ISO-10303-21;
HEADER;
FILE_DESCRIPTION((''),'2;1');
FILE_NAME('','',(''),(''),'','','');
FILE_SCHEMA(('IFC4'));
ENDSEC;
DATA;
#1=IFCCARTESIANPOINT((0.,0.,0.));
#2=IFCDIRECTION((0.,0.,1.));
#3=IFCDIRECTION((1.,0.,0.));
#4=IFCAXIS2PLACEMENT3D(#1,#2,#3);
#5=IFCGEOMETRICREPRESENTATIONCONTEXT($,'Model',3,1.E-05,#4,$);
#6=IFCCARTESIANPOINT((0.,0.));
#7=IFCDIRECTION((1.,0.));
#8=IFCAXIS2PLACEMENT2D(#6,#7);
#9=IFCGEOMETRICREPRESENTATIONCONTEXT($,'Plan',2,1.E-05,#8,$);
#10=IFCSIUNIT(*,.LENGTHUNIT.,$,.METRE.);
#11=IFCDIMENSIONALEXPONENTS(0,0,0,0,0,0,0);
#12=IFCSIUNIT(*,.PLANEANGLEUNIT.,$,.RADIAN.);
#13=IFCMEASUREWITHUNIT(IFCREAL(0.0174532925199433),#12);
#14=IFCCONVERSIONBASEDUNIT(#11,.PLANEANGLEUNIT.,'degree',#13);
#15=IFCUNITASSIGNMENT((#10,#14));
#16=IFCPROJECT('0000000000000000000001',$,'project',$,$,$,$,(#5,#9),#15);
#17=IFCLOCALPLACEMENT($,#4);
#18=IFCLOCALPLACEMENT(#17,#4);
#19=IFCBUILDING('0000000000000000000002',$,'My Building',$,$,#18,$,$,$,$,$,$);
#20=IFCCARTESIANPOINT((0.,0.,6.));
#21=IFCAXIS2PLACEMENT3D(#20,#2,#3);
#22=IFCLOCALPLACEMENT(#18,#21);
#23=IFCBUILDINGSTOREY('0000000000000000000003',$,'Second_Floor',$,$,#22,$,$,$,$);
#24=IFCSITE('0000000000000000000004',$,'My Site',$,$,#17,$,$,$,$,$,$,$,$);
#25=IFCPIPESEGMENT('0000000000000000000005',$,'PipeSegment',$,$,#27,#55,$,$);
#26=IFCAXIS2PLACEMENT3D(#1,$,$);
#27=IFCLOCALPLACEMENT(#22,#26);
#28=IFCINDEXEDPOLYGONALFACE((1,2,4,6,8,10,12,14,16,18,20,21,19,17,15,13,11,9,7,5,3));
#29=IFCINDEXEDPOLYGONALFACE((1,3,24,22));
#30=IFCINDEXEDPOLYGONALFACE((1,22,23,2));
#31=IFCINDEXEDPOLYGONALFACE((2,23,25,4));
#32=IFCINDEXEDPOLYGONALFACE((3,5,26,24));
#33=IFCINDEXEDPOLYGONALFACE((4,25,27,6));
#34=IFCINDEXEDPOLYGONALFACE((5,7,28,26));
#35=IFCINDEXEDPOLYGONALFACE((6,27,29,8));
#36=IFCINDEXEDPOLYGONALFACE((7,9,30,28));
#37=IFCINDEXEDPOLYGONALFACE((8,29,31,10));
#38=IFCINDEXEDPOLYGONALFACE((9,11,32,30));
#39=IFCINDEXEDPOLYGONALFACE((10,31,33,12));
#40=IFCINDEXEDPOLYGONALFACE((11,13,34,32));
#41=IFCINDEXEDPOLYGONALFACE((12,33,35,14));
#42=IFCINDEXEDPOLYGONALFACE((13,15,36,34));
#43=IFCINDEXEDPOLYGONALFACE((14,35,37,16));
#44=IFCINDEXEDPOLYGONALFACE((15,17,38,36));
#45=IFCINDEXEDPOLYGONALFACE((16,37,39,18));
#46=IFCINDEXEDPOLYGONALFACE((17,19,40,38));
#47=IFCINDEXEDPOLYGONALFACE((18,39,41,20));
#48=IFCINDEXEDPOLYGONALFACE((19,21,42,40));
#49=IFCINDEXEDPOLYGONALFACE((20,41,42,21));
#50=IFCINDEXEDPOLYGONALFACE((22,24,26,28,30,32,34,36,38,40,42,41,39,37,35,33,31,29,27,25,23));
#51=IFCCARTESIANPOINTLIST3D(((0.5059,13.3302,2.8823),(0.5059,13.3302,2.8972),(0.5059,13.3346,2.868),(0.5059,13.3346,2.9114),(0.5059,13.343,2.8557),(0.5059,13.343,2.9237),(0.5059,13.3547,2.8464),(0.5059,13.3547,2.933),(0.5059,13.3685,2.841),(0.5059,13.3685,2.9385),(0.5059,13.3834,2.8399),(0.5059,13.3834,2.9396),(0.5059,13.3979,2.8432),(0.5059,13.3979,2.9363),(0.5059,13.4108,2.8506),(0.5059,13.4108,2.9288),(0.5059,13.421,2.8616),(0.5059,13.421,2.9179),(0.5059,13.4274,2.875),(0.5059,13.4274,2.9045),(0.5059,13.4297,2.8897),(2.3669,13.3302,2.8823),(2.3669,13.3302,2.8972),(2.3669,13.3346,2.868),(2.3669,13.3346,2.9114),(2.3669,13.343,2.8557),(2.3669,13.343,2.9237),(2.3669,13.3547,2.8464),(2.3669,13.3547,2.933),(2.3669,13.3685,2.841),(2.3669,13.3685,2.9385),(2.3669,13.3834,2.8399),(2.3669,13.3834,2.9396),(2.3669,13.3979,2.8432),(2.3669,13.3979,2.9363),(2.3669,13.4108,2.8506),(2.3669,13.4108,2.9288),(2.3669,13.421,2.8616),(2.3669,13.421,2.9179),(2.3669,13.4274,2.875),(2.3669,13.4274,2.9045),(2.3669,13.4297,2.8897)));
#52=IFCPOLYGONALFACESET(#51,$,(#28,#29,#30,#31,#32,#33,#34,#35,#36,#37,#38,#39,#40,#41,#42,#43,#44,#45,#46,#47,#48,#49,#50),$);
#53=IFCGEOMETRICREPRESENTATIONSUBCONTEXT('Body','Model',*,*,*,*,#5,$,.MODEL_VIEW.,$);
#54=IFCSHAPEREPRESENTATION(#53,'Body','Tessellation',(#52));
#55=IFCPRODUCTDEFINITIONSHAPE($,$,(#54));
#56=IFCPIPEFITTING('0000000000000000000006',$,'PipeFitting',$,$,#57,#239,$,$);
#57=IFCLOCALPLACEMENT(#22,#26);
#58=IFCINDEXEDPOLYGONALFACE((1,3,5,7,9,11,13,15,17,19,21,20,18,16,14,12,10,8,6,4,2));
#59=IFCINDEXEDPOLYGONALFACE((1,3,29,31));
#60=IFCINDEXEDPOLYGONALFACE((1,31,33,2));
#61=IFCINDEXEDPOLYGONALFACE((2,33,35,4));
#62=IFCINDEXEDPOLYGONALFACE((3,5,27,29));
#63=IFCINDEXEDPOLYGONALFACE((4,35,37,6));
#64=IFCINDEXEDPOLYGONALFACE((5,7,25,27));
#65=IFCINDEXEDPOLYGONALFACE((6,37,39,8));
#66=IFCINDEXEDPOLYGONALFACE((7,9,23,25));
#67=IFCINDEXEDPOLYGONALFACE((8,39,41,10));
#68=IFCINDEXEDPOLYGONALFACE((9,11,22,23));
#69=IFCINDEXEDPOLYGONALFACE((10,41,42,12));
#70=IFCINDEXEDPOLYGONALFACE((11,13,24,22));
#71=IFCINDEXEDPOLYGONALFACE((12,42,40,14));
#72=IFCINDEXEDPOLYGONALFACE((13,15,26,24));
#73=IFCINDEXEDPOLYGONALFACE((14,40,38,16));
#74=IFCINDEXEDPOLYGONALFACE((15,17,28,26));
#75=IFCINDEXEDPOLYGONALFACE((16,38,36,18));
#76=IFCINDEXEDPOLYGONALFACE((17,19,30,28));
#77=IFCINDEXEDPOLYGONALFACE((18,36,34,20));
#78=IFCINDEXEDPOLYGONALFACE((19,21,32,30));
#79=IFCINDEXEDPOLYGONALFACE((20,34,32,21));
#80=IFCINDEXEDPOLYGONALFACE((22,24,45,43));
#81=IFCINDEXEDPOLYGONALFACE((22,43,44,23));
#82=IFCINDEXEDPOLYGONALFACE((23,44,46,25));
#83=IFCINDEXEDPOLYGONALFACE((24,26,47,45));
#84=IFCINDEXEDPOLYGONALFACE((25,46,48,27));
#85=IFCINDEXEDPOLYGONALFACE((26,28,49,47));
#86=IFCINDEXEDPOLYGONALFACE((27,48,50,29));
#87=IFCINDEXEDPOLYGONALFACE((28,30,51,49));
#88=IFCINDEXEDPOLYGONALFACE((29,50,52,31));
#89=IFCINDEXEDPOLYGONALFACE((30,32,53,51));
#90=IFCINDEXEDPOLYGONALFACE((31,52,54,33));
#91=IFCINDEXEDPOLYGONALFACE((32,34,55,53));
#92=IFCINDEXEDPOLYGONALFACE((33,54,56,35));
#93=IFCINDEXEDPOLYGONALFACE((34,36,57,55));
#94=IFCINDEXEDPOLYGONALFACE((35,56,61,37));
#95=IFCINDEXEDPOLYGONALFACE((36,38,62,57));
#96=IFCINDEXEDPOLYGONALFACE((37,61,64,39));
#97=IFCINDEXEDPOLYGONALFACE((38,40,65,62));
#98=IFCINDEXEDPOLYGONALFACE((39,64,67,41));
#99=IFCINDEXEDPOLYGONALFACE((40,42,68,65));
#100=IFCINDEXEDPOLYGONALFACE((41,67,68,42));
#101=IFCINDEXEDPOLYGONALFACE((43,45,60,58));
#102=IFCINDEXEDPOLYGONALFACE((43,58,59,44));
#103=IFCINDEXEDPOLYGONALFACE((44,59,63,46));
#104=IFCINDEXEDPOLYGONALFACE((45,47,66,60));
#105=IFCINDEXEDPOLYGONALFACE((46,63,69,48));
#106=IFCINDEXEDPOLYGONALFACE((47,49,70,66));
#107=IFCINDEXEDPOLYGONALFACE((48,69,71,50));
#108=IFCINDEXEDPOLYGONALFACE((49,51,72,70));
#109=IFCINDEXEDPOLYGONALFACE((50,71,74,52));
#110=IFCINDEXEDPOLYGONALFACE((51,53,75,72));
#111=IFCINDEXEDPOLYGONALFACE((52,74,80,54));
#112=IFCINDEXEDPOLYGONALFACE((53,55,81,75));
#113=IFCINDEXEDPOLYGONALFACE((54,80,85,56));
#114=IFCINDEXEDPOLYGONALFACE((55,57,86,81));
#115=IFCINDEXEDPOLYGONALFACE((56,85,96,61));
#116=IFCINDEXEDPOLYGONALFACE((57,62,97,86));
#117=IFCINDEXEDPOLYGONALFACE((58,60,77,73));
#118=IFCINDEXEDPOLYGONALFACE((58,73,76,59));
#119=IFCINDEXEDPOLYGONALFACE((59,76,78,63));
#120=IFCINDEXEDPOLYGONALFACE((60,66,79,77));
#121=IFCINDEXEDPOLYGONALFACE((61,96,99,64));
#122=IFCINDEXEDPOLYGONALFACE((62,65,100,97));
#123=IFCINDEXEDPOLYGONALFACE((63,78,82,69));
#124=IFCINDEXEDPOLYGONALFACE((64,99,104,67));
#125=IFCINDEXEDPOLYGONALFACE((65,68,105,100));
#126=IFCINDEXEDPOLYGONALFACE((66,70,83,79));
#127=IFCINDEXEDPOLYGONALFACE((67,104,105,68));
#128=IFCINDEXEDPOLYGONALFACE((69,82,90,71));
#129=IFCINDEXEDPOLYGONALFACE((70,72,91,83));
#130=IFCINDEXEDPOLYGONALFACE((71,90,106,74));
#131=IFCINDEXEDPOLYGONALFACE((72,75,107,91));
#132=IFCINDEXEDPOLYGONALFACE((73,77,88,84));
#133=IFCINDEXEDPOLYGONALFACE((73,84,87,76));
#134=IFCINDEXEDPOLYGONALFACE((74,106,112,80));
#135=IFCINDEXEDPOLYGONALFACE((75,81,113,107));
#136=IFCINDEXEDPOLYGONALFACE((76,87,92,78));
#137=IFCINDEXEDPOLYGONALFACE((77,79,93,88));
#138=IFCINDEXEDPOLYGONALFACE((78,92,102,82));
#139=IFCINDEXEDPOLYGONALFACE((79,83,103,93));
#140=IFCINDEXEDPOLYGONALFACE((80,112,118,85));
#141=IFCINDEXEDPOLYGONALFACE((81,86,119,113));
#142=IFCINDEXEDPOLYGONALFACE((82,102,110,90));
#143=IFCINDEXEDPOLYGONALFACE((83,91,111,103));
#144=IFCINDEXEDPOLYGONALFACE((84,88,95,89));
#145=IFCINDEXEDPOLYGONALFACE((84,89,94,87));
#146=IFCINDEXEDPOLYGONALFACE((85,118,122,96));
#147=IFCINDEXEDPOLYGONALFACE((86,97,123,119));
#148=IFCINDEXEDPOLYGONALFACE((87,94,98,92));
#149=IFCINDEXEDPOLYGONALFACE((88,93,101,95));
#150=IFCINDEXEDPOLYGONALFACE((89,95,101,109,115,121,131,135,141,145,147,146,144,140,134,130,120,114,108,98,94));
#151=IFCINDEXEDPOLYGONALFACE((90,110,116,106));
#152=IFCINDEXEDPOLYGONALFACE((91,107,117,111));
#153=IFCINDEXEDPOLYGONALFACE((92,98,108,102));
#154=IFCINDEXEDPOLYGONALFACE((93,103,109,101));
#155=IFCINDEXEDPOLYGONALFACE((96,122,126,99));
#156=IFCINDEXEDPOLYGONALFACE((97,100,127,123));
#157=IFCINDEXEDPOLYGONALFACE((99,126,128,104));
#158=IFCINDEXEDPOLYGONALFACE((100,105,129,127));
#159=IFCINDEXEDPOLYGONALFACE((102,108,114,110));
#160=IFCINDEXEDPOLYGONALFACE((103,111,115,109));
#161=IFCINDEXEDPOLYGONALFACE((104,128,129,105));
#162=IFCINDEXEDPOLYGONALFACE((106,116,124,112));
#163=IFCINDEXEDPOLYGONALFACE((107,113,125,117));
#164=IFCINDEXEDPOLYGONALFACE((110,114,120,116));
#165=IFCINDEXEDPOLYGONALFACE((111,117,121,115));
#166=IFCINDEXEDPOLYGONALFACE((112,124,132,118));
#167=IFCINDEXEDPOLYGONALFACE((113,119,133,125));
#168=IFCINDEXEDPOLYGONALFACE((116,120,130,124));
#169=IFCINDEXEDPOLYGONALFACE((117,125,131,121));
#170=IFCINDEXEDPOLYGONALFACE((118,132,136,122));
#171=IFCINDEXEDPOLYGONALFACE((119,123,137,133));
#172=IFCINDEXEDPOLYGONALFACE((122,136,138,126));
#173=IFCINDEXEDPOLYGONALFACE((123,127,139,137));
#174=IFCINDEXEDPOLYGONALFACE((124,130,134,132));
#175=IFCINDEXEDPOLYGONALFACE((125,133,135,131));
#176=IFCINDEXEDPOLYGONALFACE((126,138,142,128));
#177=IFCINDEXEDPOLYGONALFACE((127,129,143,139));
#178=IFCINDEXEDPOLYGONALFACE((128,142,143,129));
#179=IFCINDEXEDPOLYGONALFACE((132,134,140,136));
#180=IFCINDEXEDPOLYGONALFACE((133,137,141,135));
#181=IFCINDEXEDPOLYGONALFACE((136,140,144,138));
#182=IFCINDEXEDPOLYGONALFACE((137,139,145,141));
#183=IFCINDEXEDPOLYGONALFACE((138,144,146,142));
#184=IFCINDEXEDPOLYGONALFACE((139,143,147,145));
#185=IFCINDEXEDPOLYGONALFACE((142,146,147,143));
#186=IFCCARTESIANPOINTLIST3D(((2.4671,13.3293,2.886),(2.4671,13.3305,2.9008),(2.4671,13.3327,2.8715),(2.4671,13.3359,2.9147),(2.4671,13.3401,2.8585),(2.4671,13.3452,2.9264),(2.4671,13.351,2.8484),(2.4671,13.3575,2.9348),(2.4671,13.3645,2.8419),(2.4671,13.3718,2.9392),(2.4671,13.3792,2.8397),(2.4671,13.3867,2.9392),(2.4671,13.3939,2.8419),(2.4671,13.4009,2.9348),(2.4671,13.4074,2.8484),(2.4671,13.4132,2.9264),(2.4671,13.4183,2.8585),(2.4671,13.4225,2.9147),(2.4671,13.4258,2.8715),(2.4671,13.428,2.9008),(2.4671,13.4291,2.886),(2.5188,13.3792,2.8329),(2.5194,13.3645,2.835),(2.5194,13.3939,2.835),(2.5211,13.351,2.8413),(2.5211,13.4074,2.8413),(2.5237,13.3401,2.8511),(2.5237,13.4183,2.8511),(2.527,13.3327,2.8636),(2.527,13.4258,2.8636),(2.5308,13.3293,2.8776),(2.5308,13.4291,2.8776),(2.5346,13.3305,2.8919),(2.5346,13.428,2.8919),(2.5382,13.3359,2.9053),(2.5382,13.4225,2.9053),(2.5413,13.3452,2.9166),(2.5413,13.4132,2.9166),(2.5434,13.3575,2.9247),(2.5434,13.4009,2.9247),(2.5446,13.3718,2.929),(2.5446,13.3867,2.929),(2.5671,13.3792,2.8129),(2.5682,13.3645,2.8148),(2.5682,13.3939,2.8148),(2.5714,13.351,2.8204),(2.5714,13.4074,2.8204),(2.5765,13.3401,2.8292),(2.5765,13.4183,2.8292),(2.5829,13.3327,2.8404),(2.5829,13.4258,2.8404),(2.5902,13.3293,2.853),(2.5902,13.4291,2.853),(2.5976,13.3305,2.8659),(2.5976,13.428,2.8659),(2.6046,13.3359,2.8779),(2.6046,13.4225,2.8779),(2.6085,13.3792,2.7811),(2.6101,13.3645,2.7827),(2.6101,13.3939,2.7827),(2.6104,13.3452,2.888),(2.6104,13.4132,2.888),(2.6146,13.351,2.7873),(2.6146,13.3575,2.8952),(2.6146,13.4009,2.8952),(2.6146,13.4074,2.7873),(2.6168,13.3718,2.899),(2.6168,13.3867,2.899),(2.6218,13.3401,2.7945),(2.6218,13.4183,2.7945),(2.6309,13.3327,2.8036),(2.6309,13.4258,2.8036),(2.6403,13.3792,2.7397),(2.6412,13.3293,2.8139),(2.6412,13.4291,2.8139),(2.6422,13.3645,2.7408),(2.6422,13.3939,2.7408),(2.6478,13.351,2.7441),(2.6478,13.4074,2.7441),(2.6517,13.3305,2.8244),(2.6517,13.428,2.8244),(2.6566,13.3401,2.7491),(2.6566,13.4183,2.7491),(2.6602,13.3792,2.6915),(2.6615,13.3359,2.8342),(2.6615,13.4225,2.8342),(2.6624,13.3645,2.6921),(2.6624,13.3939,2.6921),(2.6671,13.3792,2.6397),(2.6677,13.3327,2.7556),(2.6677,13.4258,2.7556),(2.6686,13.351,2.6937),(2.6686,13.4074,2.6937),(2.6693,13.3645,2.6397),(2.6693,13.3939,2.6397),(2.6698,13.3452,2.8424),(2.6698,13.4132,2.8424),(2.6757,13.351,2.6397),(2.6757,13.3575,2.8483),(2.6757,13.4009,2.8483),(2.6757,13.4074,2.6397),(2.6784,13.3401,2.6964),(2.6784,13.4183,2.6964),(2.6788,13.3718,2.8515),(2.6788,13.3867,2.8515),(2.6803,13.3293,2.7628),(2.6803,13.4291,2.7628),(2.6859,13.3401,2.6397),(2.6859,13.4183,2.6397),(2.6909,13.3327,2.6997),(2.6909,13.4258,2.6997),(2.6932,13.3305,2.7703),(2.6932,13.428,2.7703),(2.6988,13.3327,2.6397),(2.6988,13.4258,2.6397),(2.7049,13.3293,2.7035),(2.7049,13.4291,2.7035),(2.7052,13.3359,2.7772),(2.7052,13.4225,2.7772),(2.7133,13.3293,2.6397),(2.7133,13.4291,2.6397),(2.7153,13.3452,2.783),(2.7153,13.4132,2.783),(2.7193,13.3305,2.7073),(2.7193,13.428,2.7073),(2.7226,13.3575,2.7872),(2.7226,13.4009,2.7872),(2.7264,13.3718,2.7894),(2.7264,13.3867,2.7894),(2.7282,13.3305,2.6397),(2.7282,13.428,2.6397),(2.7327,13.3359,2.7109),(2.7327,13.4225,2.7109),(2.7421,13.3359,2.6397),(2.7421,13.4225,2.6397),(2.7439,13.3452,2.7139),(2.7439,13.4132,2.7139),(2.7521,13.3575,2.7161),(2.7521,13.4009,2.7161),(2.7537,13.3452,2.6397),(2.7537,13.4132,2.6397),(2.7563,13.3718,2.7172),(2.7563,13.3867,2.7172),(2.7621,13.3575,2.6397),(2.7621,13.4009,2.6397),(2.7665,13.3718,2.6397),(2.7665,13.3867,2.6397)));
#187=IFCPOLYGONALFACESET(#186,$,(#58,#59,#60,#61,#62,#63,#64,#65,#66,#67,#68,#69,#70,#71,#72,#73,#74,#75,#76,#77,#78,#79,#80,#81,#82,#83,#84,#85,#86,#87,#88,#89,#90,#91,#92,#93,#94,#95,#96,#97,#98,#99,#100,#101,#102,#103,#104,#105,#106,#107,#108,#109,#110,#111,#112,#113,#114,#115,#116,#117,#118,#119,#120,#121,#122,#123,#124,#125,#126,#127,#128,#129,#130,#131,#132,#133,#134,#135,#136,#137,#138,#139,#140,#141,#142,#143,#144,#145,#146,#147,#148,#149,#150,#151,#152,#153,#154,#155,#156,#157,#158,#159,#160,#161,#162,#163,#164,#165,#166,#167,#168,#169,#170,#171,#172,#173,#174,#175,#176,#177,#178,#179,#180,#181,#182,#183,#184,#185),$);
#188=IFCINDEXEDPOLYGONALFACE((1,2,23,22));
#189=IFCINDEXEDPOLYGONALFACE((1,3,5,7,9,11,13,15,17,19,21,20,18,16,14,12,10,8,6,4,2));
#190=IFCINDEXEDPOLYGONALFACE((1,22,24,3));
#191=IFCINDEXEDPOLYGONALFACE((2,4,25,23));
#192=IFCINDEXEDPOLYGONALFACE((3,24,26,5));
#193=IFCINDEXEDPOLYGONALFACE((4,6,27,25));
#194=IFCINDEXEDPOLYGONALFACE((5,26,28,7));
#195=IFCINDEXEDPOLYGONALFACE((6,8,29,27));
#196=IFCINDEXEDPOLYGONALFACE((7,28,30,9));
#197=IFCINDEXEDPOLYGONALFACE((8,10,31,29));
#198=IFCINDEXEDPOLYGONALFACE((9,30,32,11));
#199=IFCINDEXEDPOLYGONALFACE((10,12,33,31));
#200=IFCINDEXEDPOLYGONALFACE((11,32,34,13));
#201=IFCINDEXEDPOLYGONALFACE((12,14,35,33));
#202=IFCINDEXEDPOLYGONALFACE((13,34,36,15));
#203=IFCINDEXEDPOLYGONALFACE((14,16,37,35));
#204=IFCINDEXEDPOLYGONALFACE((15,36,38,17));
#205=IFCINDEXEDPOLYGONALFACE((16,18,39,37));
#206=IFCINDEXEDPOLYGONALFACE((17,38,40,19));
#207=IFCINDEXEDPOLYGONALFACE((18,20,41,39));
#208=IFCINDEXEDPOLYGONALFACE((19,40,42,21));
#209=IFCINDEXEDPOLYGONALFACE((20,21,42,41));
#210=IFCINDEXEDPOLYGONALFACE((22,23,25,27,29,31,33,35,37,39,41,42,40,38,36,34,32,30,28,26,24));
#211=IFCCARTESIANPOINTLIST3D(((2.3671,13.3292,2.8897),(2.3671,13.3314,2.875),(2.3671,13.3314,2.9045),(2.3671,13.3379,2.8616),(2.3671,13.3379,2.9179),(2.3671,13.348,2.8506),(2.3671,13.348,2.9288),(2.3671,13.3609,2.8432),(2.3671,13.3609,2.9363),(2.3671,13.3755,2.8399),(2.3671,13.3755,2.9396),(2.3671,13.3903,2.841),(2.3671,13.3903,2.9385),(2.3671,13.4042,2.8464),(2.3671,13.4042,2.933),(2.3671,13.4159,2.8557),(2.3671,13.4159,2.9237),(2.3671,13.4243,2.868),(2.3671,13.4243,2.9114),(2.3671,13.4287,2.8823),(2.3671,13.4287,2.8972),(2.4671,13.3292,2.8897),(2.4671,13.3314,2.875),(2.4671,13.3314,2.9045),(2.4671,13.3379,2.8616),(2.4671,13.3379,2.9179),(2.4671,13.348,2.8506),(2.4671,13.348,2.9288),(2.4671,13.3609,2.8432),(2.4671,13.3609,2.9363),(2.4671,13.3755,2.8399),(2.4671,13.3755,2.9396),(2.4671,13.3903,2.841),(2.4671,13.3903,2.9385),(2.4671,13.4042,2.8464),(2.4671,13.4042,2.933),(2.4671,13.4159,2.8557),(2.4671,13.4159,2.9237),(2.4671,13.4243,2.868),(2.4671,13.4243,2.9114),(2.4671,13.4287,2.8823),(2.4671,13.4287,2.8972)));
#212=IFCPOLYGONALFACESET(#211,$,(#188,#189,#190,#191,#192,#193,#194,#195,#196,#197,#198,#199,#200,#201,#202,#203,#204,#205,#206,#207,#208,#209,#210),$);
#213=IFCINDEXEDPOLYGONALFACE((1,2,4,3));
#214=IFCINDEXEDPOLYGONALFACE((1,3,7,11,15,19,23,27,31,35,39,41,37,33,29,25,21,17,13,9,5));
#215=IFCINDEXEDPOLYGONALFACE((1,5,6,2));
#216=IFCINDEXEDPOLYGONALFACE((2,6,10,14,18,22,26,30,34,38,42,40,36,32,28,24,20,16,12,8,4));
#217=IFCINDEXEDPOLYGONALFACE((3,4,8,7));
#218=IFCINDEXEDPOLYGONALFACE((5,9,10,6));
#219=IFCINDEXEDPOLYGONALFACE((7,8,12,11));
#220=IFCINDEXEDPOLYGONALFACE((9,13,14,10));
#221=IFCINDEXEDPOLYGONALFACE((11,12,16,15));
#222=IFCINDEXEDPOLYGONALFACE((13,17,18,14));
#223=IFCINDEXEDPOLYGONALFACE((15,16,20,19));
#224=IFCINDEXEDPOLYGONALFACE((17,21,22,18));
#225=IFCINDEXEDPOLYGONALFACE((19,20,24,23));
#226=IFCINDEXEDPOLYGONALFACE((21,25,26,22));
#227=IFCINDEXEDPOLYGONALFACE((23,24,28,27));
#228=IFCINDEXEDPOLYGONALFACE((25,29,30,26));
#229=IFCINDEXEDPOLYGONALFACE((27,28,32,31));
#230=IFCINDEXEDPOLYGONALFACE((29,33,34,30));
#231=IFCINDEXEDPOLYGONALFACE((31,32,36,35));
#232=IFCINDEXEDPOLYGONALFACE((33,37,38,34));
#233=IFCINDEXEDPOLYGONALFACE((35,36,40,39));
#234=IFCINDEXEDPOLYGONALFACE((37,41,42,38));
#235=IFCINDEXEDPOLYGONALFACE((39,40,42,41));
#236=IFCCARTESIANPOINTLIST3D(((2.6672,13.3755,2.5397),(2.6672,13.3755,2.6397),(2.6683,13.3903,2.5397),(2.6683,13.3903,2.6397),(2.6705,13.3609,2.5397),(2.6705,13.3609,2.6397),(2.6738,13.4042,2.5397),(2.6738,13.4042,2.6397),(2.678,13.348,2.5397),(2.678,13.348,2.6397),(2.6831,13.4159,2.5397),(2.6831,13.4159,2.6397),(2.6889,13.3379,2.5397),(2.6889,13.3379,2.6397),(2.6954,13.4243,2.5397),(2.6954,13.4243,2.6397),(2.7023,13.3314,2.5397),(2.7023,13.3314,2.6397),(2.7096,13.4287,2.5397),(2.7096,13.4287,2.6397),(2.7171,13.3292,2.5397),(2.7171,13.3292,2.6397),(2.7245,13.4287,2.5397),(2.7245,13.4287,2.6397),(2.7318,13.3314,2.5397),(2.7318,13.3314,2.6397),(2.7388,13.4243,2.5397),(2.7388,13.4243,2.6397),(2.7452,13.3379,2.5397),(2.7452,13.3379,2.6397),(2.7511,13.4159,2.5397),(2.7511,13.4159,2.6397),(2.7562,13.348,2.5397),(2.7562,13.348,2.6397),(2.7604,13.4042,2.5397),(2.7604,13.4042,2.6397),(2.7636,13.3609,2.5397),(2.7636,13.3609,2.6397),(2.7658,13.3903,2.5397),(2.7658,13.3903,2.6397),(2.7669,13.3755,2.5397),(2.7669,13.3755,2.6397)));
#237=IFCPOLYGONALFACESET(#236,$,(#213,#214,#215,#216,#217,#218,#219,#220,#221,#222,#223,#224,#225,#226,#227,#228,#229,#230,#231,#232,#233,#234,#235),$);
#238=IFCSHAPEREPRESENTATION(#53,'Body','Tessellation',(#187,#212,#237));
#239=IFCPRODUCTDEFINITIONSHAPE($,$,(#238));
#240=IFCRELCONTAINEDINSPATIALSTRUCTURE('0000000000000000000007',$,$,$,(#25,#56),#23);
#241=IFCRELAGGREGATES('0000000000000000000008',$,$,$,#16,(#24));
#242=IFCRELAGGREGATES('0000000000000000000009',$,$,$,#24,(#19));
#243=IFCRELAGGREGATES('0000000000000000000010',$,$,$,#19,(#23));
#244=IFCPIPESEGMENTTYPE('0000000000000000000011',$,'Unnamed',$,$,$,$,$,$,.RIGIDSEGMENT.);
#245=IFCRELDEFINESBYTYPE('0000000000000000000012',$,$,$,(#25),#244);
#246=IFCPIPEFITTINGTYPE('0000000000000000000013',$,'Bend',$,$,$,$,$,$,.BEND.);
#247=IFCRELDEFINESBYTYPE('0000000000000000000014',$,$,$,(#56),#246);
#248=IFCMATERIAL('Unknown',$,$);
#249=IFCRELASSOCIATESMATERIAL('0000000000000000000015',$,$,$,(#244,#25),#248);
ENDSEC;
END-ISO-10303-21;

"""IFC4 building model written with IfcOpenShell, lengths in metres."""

from ifc_helpers import new_model, entity, si_unit, converted_unit, frame, origin_with_axes, origin_2d_with_axis, place, context, subcontext, project, spatial, circle, extrude, source, transform, mapped, material, material_profile, profile_set, profile_usage, type_object, type_shapes, element, save


model = new_model("IFC4")

# Units and contexts
model_context = context("Model", 3, precision=1e-05, world=origin_with_axes())
plan_context = context("Plan", 2, precision=1e-05, world=origin_2d_with_axis())
body_context_1 = subcontext(model_context, "Body", "Model", "MODEL_VIEW")
ifc_project = project(units=[si_unit("LENGTHUNIT", "METRE"), converted_unit("PLANEANGLEUNIT", "degree", entity("IfcReal", 0.0174532925199433), si_unit("PLANEANGLEUNIT", "RADIAN"), dimensions=[0, 0, 0, 0, 0, 0, 0])], contexts=[model_context, plan_context])

# Site, building, storey
site_placement = place(None, origin_with_axes())
site = spatial("IfcSite", under=ifc_project, at=site_placement, Name="My Site")
building_placement = place(site_placement, origin_with_axes())
building = spatial("IfcBuilding", under=site, at=building_placement, Name="My Building")
storey_placement = place(building_placement, frame((0.0, 0.0, 6.0), z_axis=(0.0, 0.0, 1.0), x_axis=(1.0, 0.0, 0.0)))
storey = spatial("IfcBuildingStorey", under=building, at=storey_placement, Name="Second_Floor")

# Shared definitions
ifc_material = material(Name="Unknown")

# Pipe segment
ifc_material_profile_1 = material_profile(ifc_material, circle(Radius=0.05))
ifc_profile_set_1 = profile_set([ifc_material_profile_1])
pipe_segment_type = type_object("IfcPipeSegmentType", Name="Unnamed", PredefinedType="RIGIDSEGMENT", material=ifc_profile_set_1)
ifc_profile_usage_1 = profile_usage(ifc_profile_set_1, cardinal=5)
pipe_segment_1_placement = place(storey_placement, frame((0.5059, 13.3797, 2.8897), z_axis=(1.0, 0.0, 0.0), x_axis=(0.0, 1.0, 0.0)))
element("IfcPipeSegment", 1, at=pipe_segment_1_placement, inside=storey, type_object=pipe_segment_type, material=ifc_profile_usage_1, Name="PipeSegment", context=body_context_1, shape_type="SweptSolid", body=[
    extrude(circle(Radius=0.05), origin_with_axes(), (0.0, 0.0, 1.0), 1.861),
])

# Pipe fitting
pipe_fitting_type = type_object("IfcPipeFittingType", Name="Bend", PredefinedType="BEND")
shared_shape_1 = source(origin_with_axes(), body_context_1, "Body", "SolidModel", [
    entity("IfcSweptDiskSolid", entity("IfcIndexedPolyCurve", entity("IfcCartesianPointList3D", [[0.0, 0.0, -0.1], [0.0, -0.0732, -0.2768], [0.0, -0.25, -0.35]]), [entity("IfcArcIndex", [1, 2, 3])]), 0.05),
    extrude(circle(Radius=0.05), origin_with_axes(), (0.0, 0.0, -1.0), 0.1),
    extrude(circle(Radius=0.05), frame((0.0, -0.25, -0.35), z_axis=(0.0, -1.0, 0.0), x_axis=(1.0, 0.0, 0.0)), (0.0, 0.0, 1.0), 0.1),
])
type_shapes(pipe_fitting_type, [shared_shape_1])
pipe_fitting_placement = place(storey_placement, frame((2.3671, 13.3792, 2.8897), z_axis=(-1.0, 0.0, 0.0), x_axis=(0.0, -1.0, 0.0)))
element("IfcPipeFitting", 2, at=pipe_fitting_placement, inside=storey, type_object=pipe_fitting_type, Name="PipeFitting", context=body_context_1, shape_type="MappedRepresentation", body=[
    mapped(shared_shape_1, transform((0.0, 0.0, 0.0), x_axis=(1.0, 0.0, 0.0), y_axis=(0.0, 1.0, 0.0), z_axis=(0.0, 0.0, 1.0), scale=1.0)),
])

save(model, "model.ifc")
